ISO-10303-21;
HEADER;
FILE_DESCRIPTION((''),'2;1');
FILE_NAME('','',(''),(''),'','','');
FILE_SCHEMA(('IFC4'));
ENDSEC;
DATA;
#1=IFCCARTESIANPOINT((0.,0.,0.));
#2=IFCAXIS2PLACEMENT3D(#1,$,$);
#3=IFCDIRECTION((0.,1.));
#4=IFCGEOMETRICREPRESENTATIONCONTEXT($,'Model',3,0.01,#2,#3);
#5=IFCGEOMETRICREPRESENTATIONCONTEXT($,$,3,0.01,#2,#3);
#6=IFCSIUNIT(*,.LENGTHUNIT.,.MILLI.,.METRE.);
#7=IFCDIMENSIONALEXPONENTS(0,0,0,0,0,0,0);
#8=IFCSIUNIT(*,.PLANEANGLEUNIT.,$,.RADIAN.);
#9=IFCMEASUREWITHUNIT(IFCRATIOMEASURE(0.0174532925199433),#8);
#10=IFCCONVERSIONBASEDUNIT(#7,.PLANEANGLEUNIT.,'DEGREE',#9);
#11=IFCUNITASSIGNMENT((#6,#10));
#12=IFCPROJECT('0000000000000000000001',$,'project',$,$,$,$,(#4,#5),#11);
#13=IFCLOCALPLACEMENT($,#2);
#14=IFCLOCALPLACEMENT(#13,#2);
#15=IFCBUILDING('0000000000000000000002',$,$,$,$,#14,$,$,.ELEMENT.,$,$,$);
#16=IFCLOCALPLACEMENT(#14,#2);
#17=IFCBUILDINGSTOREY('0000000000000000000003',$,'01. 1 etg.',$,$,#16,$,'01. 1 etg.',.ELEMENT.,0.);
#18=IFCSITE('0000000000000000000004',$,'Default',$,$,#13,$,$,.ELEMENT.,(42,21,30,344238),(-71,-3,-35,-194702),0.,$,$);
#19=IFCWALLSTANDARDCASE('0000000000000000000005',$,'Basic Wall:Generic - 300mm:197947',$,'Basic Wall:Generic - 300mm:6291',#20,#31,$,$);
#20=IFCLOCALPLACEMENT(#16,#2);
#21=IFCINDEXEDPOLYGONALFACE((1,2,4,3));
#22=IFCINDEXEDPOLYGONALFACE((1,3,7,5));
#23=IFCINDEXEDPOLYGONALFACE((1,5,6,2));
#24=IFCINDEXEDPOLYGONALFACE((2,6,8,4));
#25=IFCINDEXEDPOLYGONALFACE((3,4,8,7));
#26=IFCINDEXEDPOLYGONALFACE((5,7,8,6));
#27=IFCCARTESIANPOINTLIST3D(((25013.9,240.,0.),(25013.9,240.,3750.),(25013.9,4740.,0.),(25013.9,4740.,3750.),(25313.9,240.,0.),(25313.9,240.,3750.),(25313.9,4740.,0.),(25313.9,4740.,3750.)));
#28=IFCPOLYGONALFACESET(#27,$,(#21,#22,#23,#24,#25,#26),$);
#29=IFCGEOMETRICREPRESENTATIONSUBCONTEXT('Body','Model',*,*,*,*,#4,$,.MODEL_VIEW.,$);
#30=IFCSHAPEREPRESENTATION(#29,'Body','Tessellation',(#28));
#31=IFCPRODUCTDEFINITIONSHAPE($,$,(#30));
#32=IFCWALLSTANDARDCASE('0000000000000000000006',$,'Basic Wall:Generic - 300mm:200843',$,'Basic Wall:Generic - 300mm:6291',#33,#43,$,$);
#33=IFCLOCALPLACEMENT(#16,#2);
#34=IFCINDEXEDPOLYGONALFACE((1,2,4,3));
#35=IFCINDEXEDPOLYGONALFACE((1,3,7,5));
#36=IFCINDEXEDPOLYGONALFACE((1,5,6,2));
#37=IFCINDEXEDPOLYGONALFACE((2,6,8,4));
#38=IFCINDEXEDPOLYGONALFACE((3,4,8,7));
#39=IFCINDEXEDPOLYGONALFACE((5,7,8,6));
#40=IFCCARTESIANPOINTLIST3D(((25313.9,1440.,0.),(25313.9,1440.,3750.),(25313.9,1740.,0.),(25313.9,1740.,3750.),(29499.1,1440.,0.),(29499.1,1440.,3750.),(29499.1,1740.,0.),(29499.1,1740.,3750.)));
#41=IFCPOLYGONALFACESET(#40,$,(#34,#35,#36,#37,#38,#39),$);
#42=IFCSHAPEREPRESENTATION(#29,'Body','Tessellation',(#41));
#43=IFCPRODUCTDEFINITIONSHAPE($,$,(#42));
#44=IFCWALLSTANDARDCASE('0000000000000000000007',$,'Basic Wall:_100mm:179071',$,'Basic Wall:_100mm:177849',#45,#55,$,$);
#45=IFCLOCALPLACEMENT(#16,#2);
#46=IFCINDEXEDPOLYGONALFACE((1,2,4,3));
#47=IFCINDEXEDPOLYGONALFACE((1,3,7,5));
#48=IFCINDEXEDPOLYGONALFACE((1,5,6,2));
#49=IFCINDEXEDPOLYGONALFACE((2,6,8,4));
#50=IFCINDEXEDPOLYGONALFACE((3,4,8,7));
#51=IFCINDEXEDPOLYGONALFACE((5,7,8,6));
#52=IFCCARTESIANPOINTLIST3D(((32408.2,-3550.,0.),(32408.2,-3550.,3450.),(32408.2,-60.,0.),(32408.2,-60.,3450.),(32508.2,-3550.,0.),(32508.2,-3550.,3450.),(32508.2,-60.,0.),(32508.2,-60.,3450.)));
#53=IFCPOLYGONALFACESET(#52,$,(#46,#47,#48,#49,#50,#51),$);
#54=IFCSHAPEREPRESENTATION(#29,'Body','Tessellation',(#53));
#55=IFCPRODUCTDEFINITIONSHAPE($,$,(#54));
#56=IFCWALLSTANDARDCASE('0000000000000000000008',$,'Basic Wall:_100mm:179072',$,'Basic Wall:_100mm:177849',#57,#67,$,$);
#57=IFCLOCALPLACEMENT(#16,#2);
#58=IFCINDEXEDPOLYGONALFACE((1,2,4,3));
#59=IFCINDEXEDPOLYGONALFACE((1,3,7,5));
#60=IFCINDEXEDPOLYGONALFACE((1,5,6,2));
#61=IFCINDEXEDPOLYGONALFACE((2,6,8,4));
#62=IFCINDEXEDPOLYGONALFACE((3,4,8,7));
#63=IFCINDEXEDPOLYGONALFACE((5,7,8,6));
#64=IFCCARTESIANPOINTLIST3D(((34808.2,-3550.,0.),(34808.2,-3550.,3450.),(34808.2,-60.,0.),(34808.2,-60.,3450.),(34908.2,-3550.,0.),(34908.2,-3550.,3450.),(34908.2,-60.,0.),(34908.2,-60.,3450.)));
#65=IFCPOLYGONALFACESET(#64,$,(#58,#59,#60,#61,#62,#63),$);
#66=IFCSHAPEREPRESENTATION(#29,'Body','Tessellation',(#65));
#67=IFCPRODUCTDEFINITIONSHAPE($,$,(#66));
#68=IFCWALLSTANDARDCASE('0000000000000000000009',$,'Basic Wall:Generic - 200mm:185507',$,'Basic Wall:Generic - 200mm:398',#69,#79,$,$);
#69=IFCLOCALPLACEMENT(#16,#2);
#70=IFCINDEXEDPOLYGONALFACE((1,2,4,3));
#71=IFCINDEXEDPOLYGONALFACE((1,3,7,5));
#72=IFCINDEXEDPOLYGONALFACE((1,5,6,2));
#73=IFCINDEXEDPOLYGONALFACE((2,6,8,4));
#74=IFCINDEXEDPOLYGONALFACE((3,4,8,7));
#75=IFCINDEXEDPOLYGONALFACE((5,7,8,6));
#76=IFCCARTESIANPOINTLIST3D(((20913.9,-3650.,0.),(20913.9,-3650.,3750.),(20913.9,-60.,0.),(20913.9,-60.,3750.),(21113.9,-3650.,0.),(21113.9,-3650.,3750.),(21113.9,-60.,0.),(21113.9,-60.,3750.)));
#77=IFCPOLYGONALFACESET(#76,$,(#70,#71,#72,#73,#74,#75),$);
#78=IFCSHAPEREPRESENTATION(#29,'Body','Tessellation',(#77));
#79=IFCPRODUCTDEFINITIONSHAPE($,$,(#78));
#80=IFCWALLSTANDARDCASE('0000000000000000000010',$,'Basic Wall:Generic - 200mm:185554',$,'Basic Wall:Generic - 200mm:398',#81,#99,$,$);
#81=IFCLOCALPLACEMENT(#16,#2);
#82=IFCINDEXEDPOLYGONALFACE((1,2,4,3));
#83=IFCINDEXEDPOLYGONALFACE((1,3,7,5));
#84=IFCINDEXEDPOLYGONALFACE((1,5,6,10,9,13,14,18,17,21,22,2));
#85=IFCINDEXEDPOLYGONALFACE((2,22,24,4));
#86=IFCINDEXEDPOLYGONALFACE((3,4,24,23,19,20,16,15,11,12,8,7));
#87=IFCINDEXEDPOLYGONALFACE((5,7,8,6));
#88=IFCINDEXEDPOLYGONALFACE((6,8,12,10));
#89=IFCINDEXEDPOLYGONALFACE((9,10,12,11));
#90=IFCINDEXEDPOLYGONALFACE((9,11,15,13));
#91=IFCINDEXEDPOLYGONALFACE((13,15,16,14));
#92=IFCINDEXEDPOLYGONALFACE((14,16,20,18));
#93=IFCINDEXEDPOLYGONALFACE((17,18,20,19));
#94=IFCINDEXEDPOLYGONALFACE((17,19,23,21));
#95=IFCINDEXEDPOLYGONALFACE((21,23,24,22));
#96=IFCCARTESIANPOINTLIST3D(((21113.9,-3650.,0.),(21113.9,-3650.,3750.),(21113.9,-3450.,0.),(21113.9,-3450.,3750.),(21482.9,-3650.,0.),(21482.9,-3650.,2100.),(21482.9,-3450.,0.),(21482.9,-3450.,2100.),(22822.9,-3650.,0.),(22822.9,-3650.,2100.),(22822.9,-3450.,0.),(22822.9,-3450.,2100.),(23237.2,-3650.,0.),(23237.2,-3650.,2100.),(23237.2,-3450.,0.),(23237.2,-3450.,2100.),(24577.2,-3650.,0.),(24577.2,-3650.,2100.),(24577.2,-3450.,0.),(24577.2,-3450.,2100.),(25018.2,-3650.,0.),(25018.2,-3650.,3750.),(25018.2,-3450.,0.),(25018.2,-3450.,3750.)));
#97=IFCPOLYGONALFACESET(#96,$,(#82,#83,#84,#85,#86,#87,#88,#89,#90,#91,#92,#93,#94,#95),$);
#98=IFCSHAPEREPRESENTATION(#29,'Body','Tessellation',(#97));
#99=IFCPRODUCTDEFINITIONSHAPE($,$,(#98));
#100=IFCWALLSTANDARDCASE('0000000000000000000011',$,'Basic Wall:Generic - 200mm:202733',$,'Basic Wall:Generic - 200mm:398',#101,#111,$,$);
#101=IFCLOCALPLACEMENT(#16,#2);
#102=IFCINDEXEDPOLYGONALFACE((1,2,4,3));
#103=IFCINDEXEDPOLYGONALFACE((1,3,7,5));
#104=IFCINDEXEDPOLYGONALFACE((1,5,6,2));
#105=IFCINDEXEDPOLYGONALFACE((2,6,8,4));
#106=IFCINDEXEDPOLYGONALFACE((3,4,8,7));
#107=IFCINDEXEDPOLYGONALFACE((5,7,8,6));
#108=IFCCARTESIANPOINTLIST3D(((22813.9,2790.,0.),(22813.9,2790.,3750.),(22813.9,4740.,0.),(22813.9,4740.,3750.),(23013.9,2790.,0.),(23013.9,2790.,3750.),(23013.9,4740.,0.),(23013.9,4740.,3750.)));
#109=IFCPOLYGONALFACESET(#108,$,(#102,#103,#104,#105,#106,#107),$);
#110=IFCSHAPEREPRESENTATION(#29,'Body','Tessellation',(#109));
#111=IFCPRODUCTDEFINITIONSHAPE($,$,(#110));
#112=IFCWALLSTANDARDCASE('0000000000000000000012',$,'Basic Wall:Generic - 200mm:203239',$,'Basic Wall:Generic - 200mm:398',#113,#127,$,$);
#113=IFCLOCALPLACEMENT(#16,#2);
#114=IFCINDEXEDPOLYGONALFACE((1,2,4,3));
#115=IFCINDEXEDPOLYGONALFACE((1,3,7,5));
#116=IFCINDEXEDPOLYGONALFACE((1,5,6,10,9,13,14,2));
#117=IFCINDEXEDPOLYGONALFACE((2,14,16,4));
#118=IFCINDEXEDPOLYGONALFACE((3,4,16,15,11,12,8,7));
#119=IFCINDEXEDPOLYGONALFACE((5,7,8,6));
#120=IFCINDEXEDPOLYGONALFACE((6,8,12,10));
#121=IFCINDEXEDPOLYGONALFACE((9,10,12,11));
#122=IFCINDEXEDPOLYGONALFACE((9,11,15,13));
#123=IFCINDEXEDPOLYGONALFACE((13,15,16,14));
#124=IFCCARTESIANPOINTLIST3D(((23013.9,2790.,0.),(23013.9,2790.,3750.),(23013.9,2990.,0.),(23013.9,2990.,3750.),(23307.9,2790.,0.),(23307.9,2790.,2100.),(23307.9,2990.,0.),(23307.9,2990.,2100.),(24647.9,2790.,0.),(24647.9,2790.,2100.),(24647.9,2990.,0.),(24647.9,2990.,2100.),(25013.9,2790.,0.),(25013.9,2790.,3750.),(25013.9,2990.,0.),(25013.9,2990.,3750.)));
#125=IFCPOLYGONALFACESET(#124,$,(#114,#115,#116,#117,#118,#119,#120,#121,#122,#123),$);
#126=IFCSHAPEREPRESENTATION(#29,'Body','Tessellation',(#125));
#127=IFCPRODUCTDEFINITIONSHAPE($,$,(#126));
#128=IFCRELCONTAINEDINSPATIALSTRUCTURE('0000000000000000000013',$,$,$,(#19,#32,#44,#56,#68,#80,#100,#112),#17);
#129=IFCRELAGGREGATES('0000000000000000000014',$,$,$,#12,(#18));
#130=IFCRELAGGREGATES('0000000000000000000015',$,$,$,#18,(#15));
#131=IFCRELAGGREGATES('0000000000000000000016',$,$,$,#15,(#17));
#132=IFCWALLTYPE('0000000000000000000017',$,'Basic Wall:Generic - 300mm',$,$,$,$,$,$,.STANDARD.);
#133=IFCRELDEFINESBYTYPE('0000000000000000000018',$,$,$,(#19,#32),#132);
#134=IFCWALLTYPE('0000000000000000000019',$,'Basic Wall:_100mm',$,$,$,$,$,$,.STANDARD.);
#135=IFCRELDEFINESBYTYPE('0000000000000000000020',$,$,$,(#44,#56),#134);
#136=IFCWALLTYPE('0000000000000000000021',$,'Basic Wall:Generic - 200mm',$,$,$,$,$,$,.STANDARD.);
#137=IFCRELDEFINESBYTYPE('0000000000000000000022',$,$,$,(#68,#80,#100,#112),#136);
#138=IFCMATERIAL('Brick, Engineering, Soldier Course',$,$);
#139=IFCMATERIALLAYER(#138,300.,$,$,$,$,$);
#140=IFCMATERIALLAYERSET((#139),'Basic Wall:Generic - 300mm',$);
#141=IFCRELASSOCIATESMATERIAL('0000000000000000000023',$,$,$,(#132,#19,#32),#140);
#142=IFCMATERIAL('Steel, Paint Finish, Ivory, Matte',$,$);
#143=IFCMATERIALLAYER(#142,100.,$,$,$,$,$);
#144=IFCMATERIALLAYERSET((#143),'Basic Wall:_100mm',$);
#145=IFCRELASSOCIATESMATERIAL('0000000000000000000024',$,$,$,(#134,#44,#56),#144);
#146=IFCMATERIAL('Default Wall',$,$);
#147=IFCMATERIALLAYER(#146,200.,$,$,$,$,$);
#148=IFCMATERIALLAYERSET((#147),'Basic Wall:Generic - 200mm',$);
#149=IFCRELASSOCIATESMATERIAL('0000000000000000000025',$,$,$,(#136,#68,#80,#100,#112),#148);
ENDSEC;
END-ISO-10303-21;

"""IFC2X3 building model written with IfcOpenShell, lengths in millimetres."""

from ifc_helpers import new_model, entity, si_unit, converted_unit, direction, frame, frame_2d, origin, origin_2d_with_axis, place, context, subcontext, project, spatial, polyline, rectangle, extrude, clip, bounded_halfspace, material, layer, layer_set, layer_usage, type_object, element, save


model = new_model("IFC2X3")

# Units and contexts
model_context = context("Model", 3, precision=0.01, world=origin(), true_north=direction((0.0, 1.0)))
context_of_model = context(None, 3, precision=0.01, world=origin(), true_north=direction((0.0, 1.0)))
body_context = subcontext(model_context, "Body", "Model", "MODEL_VIEW")
ifc_project = project(units=[si_unit("LENGTHUNIT", "METRE", prefix="MILLI"), converted_unit("PLANEANGLEUNIT", "DEGREE", entity("IfcRatioMeasure", 0.0174532925199433), si_unit("PLANEANGLEUNIT", "RADIAN"), dimensions=[0, 0, 0, 0, 0, 0, 0])], contexts=[model_context, context_of_model])

# Site, building, storey
site_placement = place(None, origin())
site = spatial("IfcSite", under=ifc_project, at=site_placement, Name="Default", CompositionType="ELEMENT", RefLatitude=(42, 21, 30, 344238), RefLongitude=(-71, -3, -35, -194702), RefElevation=0.0)
building_placement = place(site_placement, origin())
building = spatial("IfcBuilding", under=site, at=building_placement, CompositionType="ELEMENT")
storey_placement = place(building_placement, origin())
storey = spatial("IfcBuildingStorey", under=building, at=storey_placement, Name="01. 1 etg.", LongName="01. 1 etg.", CompositionType="ELEMENT", Elevation=0.0)

# Shared definitions
ifc_material_1 = material(Name="Brick, Engineering, Soldier Course")
ifc_layer_1 = layer(ifc_material_1, 300.0)
ifc_layer_set_1 = layer_set([ifc_layer_1], Name="Basic Wall:Generic - 300mm")
wall_type_1 = type_object("IfcWallType", Name="Basic Wall:Generic - 300mm", PredefinedType="STANDARD", material=ifc_layer_set_1)

# Walls
ifc_layer_usage_1 = layer_usage(ifc_layer_set_1, "AXIS2", "NEGATIVE", 150.0)
wall_1_placement = place(storey_placement, frame((25163.9, 4740.0, 0.0), z_axis=(0.0, 0.0, 1.0), x_axis=(0.0, -1.0, 0.0)))
element("IfcWallStandardCase", 1, at=wall_1_placement, inside=storey, type_object=wall_type_1, material=ifc_layer_usage_1, Name="Basic Wall:Generic - 300mm:197947", ObjectType="Basic Wall:Generic - 300mm:6291", context=body_context, shape_type="SweptSolid", body=[
    extrude(rectangle(XDim=4500.0, YDim=300.0, at=frame_2d((2250.0, 0.0), x_axis=(-1.0, 0.0))), origin(), (0.0, 0.0, 1.0), 3750.0),
])
ifc_layer_usage_2 = layer_usage(ifc_layer_set_1, "AXIS2", "NEGATIVE", 150.0)
wall_2_placement = place(storey_placement, frame((29499.1, 1590.0, 0.0), z_axis=(0.0, 0.0, 1.0), x_axis=(-1.0, 0.0, 0.0)))
element("IfcWallStandardCase", 2, at=wall_2_placement, inside=storey, type_object=wall_type_1, material=ifc_layer_usage_2, Name="Basic Wall:Generic - 300mm:200843", ObjectType="Basic Wall:Generic - 300mm:6291", context=body_context, shape_type="SweptSolid", body=[
    extrude(rectangle(XDim=4185.2, YDim=300.0, at=frame_2d((2092.6, 0.0), x_axis=(-1.0, 0.0))), origin(), (0.0, 0.0, 1.0), 3750.0),
])
ifc_material_2 = material(Name="Steel, Paint Finish, Ivory, Matte")
ifc_layer_2 = layer(ifc_material_2, 100.0)
ifc_layer_set_2 = layer_set([ifc_layer_2], Name="Basic Wall:_100mm")
ifc_layer_usage_3 = layer_usage(ifc_layer_set_2, "AXIS2", "POSITIVE", -50.0)
wall_type_2 = type_object("IfcWallType", Name="Basic Wall:_100mm", PredefinedType="STANDARD", material=ifc_layer_set_2)
wall_3_placement = place(storey_placement, frame((32458.2, -3550.0, 0.0), z_axis=(0.0, 0.0, 1.0), x_axis=(0.0, 1.0, 0.0)))
element("IfcWallStandardCase", 3, at=wall_3_placement, inside=storey, type_object=wall_type_2, material=ifc_layer_usage_3, Name="Basic Wall:_100mm:179071", ObjectType="Basic Wall:_100mm:177849", context=body_context, shape_type="Clipping", body=[
    clip(extrude(rectangle(XDim=3490.0, YDim=100.0, at=frame_2d((1745.0, 0.0), x_axis=(-1.0, 0.0))), origin(), (0.0, 0.0, 1.0), 3450.0), bounded_halfspace(frame((0.0, -50.0, 3450.0), z_axis=(0.0, 0.0, -1.0), x_axis=(-1.0, 0.0, 0.0)), True, frame((0.0, -50.0, 3450.0)), polyline([(0.0, 0.0), (3490.0, 0.0), (3490.0, 100.0), (0.0, 100.0), (0.0, 0.0)]))),
])
ifc_layer_usage_4 = layer_usage(ifc_layer_set_2, "AXIS2", "POSITIVE", -50.0)
wall_4_placement = place(storey_placement, frame((34858.2, -3550.0, 0.0), z_axis=(0.0, 0.0, 1.0), x_axis=(0.0, 1.0, 0.0)))
element("IfcWallStandardCase", 4, at=wall_4_placement, inside=storey, type_object=wall_type_2, material=ifc_layer_usage_4, Name="Basic Wall:_100mm:179072", ObjectType="Basic Wall:_100mm:177849", context=body_context, shape_type="Clipping", body=[
    clip(extrude(rectangle(XDim=3490.0, YDim=100.0, at=frame_2d((1745.0, 0.0), x_axis=(-1.0, 0.0))), origin(), (0.0, 0.0, 1.0), 3450.0), bounded_halfspace(frame((0.0, -50.0, 3450.0), z_axis=(0.0, 0.0, -1.0), x_axis=(-1.0, 0.0, 0.0)), True, frame((0.0, -50.0, 3450.0)), polyline([(0.0, 0.0), (3490.0, 0.0), (3490.0, 100.0), (0.0, 100.0), (0.0, 0.0)]))),
])
ifc_material_3 = material(Name="Default Wall")
ifc_layer_3 = layer(ifc_material_3, 200.0)
ifc_layer_set_3 = layer_set([ifc_layer_3], Name="Basic Wall:Generic - 200mm")
ifc_layer_usage_5 = layer_usage(ifc_layer_set_3, "AXIS2", "NEGATIVE", 100.0)
wall_type_3 = type_object("IfcWallType", Name="Basic Wall:Generic - 200mm", PredefinedType="STANDARD", material=ifc_layer_set_3)
wall_5_placement = place(storey_placement, frame((21013.9, -60.0, 0.0), z_axis=(0.0, 0.0, 1.0), x_axis=(0.0, -1.0, 0.0)))
element("IfcWallStandardCase", 5, at=wall_5_placement, inside=storey, type_object=wall_type_3, material=ifc_layer_usage_5, Name="Basic Wall:Generic - 200mm:185507", ObjectType="Basic Wall:Generic - 200mm:398", context=body_context, shape_type="SweptSolid", body=[
    extrude(rectangle(XDim=3590.0, YDim=200.0, at=frame_2d((1795.0, 0.0), x_axis=(-1.0, 0.0))), origin(), (0.0, 0.0, 1.0), 3750.0),
])

# Wall, openings
ifc_layer_usage_6 = layer_usage(ifc_layer_set_3, "AXIS2", "NEGATIVE", 100.0)
wall_6_placement = place(storey_placement, frame((21113.9, -3550.0, 0.0)))
wall_6 = element("IfcWallStandardCase", 6, at=wall_6_placement, inside=storey, type_object=wall_type_3, material=ifc_layer_usage_6, Name="Basic Wall:Generic - 200mm:185554", ObjectType="Basic Wall:Generic - 200mm:398", context=body_context, shape_type="SweptSolid", body=[
    extrude(rectangle(XDim=3904.3, YDim=200.0, at=frame_2d((1952.2, 0.0), x_axis=(-1.0, 0.0))), origin(), (0.0, 0.0, 1.0), 3750.0),
])
opening_1_placement = place(wall_6_placement, frame((2123.3, -1624.0, 0.0)))
element("IfcOpeningElement", 7, at=opening_1_placement, cuts=wall_6, ObjectType="Opening", context=body_context, shape_type="SweptSolid", body=[
    extrude(rectangle(XDim=2100.0, YDim=1340.0, at=origin_2d_with_axis()), frame((670.0, 0.0, 1050.0), z_axis=(0.0, 1.0, 0.0), x_axis=(0.0, 0.0, -1.0)), (0.0, 0.0, 1.0), 3048.0),
])
opening_2_placement = place(wall_6_placement, frame((369.0, -1624.0, 0.0)))
element("IfcOpeningElement", 8, at=opening_2_placement, cuts=wall_6, ObjectType="Opening", context=body_context, shape_type="SweptSolid", body=[
    extrude(rectangle(XDim=2100.0, YDim=1340.0, at=origin_2d_with_axis()), frame((670.0, 0.0, 1050.0), z_axis=(0.0, 1.0, 0.0), x_axis=(0.0, 0.0, -1.0)), (0.0, 0.0, 1.0), 3048.0),
])

# Wall
ifc_layer_usage_7 = layer_usage(ifc_layer_set_3, "AXIS2", "NEGATIVE", 100.0)
wall_7_placement = place(storey_placement, frame((22913.9, 4740.0, 0.0), z_axis=(0.0, 0.0, 1.0), x_axis=(0.0, -1.0, 0.0)))
element("IfcWallStandardCase", 9, at=wall_7_placement, inside=storey, type_object=wall_type_3, material=ifc_layer_usage_7, Name="Basic Wall:Generic - 200mm:202733", ObjectType="Basic Wall:Generic - 200mm:398", context=body_context, shape_type="SweptSolid", body=[
    extrude(rectangle(XDim=1950.0, YDim=200.0, at=frame_2d((975.0, 0.0), x_axis=(-1.0, 0.0))), origin(), (0.0, 0.0, 1.0), 3750.0),
])

# Wall, opening
ifc_layer_usage_8 = layer_usage(ifc_layer_set_3, "AXIS2", "NEGATIVE", 100.0)
wall_8_placement = place(storey_placement, frame((23013.9, 2890.0, 0.0)))
wall_8 = element("IfcWallStandardCase", 10, at=wall_8_placement, inside=storey, type_object=wall_type_3, material=ifc_layer_usage_8, Name="Basic Wall:Generic - 200mm:203239", ObjectType="Basic Wall:Generic - 200mm:398", context=body_context, shape_type="SweptSolid", body=[
    extrude(rectangle(XDim=2000.0, YDim=200.0, at=frame_2d((1000.0, 0.0), x_axis=(-1.0, 0.0))), origin(), (0.0, 0.0, 1.0), 3750.0),
])
opening_3_placement = place(wall_8_placement, frame((294.0, -1624.0, 0.0)))
element("IfcOpeningElement", 11, at=opening_3_placement, cuts=wall_8, ObjectType="Opening", context=body_context, shape_type="SweptSolid", body=[
    extrude(rectangle(XDim=2100.0, YDim=1340.0, at=frame_2d((0.0, 0.0), x_axis=(1.0, 0.0))), frame((670.0, 0.0, 1050.0), z_axis=(0.0, 1.0, 0.0), x_axis=(0.0, 0.0, -1.0)), (0.0, 0.0, 1.0), 3048.0),
])

save(model, "model.ifc")
